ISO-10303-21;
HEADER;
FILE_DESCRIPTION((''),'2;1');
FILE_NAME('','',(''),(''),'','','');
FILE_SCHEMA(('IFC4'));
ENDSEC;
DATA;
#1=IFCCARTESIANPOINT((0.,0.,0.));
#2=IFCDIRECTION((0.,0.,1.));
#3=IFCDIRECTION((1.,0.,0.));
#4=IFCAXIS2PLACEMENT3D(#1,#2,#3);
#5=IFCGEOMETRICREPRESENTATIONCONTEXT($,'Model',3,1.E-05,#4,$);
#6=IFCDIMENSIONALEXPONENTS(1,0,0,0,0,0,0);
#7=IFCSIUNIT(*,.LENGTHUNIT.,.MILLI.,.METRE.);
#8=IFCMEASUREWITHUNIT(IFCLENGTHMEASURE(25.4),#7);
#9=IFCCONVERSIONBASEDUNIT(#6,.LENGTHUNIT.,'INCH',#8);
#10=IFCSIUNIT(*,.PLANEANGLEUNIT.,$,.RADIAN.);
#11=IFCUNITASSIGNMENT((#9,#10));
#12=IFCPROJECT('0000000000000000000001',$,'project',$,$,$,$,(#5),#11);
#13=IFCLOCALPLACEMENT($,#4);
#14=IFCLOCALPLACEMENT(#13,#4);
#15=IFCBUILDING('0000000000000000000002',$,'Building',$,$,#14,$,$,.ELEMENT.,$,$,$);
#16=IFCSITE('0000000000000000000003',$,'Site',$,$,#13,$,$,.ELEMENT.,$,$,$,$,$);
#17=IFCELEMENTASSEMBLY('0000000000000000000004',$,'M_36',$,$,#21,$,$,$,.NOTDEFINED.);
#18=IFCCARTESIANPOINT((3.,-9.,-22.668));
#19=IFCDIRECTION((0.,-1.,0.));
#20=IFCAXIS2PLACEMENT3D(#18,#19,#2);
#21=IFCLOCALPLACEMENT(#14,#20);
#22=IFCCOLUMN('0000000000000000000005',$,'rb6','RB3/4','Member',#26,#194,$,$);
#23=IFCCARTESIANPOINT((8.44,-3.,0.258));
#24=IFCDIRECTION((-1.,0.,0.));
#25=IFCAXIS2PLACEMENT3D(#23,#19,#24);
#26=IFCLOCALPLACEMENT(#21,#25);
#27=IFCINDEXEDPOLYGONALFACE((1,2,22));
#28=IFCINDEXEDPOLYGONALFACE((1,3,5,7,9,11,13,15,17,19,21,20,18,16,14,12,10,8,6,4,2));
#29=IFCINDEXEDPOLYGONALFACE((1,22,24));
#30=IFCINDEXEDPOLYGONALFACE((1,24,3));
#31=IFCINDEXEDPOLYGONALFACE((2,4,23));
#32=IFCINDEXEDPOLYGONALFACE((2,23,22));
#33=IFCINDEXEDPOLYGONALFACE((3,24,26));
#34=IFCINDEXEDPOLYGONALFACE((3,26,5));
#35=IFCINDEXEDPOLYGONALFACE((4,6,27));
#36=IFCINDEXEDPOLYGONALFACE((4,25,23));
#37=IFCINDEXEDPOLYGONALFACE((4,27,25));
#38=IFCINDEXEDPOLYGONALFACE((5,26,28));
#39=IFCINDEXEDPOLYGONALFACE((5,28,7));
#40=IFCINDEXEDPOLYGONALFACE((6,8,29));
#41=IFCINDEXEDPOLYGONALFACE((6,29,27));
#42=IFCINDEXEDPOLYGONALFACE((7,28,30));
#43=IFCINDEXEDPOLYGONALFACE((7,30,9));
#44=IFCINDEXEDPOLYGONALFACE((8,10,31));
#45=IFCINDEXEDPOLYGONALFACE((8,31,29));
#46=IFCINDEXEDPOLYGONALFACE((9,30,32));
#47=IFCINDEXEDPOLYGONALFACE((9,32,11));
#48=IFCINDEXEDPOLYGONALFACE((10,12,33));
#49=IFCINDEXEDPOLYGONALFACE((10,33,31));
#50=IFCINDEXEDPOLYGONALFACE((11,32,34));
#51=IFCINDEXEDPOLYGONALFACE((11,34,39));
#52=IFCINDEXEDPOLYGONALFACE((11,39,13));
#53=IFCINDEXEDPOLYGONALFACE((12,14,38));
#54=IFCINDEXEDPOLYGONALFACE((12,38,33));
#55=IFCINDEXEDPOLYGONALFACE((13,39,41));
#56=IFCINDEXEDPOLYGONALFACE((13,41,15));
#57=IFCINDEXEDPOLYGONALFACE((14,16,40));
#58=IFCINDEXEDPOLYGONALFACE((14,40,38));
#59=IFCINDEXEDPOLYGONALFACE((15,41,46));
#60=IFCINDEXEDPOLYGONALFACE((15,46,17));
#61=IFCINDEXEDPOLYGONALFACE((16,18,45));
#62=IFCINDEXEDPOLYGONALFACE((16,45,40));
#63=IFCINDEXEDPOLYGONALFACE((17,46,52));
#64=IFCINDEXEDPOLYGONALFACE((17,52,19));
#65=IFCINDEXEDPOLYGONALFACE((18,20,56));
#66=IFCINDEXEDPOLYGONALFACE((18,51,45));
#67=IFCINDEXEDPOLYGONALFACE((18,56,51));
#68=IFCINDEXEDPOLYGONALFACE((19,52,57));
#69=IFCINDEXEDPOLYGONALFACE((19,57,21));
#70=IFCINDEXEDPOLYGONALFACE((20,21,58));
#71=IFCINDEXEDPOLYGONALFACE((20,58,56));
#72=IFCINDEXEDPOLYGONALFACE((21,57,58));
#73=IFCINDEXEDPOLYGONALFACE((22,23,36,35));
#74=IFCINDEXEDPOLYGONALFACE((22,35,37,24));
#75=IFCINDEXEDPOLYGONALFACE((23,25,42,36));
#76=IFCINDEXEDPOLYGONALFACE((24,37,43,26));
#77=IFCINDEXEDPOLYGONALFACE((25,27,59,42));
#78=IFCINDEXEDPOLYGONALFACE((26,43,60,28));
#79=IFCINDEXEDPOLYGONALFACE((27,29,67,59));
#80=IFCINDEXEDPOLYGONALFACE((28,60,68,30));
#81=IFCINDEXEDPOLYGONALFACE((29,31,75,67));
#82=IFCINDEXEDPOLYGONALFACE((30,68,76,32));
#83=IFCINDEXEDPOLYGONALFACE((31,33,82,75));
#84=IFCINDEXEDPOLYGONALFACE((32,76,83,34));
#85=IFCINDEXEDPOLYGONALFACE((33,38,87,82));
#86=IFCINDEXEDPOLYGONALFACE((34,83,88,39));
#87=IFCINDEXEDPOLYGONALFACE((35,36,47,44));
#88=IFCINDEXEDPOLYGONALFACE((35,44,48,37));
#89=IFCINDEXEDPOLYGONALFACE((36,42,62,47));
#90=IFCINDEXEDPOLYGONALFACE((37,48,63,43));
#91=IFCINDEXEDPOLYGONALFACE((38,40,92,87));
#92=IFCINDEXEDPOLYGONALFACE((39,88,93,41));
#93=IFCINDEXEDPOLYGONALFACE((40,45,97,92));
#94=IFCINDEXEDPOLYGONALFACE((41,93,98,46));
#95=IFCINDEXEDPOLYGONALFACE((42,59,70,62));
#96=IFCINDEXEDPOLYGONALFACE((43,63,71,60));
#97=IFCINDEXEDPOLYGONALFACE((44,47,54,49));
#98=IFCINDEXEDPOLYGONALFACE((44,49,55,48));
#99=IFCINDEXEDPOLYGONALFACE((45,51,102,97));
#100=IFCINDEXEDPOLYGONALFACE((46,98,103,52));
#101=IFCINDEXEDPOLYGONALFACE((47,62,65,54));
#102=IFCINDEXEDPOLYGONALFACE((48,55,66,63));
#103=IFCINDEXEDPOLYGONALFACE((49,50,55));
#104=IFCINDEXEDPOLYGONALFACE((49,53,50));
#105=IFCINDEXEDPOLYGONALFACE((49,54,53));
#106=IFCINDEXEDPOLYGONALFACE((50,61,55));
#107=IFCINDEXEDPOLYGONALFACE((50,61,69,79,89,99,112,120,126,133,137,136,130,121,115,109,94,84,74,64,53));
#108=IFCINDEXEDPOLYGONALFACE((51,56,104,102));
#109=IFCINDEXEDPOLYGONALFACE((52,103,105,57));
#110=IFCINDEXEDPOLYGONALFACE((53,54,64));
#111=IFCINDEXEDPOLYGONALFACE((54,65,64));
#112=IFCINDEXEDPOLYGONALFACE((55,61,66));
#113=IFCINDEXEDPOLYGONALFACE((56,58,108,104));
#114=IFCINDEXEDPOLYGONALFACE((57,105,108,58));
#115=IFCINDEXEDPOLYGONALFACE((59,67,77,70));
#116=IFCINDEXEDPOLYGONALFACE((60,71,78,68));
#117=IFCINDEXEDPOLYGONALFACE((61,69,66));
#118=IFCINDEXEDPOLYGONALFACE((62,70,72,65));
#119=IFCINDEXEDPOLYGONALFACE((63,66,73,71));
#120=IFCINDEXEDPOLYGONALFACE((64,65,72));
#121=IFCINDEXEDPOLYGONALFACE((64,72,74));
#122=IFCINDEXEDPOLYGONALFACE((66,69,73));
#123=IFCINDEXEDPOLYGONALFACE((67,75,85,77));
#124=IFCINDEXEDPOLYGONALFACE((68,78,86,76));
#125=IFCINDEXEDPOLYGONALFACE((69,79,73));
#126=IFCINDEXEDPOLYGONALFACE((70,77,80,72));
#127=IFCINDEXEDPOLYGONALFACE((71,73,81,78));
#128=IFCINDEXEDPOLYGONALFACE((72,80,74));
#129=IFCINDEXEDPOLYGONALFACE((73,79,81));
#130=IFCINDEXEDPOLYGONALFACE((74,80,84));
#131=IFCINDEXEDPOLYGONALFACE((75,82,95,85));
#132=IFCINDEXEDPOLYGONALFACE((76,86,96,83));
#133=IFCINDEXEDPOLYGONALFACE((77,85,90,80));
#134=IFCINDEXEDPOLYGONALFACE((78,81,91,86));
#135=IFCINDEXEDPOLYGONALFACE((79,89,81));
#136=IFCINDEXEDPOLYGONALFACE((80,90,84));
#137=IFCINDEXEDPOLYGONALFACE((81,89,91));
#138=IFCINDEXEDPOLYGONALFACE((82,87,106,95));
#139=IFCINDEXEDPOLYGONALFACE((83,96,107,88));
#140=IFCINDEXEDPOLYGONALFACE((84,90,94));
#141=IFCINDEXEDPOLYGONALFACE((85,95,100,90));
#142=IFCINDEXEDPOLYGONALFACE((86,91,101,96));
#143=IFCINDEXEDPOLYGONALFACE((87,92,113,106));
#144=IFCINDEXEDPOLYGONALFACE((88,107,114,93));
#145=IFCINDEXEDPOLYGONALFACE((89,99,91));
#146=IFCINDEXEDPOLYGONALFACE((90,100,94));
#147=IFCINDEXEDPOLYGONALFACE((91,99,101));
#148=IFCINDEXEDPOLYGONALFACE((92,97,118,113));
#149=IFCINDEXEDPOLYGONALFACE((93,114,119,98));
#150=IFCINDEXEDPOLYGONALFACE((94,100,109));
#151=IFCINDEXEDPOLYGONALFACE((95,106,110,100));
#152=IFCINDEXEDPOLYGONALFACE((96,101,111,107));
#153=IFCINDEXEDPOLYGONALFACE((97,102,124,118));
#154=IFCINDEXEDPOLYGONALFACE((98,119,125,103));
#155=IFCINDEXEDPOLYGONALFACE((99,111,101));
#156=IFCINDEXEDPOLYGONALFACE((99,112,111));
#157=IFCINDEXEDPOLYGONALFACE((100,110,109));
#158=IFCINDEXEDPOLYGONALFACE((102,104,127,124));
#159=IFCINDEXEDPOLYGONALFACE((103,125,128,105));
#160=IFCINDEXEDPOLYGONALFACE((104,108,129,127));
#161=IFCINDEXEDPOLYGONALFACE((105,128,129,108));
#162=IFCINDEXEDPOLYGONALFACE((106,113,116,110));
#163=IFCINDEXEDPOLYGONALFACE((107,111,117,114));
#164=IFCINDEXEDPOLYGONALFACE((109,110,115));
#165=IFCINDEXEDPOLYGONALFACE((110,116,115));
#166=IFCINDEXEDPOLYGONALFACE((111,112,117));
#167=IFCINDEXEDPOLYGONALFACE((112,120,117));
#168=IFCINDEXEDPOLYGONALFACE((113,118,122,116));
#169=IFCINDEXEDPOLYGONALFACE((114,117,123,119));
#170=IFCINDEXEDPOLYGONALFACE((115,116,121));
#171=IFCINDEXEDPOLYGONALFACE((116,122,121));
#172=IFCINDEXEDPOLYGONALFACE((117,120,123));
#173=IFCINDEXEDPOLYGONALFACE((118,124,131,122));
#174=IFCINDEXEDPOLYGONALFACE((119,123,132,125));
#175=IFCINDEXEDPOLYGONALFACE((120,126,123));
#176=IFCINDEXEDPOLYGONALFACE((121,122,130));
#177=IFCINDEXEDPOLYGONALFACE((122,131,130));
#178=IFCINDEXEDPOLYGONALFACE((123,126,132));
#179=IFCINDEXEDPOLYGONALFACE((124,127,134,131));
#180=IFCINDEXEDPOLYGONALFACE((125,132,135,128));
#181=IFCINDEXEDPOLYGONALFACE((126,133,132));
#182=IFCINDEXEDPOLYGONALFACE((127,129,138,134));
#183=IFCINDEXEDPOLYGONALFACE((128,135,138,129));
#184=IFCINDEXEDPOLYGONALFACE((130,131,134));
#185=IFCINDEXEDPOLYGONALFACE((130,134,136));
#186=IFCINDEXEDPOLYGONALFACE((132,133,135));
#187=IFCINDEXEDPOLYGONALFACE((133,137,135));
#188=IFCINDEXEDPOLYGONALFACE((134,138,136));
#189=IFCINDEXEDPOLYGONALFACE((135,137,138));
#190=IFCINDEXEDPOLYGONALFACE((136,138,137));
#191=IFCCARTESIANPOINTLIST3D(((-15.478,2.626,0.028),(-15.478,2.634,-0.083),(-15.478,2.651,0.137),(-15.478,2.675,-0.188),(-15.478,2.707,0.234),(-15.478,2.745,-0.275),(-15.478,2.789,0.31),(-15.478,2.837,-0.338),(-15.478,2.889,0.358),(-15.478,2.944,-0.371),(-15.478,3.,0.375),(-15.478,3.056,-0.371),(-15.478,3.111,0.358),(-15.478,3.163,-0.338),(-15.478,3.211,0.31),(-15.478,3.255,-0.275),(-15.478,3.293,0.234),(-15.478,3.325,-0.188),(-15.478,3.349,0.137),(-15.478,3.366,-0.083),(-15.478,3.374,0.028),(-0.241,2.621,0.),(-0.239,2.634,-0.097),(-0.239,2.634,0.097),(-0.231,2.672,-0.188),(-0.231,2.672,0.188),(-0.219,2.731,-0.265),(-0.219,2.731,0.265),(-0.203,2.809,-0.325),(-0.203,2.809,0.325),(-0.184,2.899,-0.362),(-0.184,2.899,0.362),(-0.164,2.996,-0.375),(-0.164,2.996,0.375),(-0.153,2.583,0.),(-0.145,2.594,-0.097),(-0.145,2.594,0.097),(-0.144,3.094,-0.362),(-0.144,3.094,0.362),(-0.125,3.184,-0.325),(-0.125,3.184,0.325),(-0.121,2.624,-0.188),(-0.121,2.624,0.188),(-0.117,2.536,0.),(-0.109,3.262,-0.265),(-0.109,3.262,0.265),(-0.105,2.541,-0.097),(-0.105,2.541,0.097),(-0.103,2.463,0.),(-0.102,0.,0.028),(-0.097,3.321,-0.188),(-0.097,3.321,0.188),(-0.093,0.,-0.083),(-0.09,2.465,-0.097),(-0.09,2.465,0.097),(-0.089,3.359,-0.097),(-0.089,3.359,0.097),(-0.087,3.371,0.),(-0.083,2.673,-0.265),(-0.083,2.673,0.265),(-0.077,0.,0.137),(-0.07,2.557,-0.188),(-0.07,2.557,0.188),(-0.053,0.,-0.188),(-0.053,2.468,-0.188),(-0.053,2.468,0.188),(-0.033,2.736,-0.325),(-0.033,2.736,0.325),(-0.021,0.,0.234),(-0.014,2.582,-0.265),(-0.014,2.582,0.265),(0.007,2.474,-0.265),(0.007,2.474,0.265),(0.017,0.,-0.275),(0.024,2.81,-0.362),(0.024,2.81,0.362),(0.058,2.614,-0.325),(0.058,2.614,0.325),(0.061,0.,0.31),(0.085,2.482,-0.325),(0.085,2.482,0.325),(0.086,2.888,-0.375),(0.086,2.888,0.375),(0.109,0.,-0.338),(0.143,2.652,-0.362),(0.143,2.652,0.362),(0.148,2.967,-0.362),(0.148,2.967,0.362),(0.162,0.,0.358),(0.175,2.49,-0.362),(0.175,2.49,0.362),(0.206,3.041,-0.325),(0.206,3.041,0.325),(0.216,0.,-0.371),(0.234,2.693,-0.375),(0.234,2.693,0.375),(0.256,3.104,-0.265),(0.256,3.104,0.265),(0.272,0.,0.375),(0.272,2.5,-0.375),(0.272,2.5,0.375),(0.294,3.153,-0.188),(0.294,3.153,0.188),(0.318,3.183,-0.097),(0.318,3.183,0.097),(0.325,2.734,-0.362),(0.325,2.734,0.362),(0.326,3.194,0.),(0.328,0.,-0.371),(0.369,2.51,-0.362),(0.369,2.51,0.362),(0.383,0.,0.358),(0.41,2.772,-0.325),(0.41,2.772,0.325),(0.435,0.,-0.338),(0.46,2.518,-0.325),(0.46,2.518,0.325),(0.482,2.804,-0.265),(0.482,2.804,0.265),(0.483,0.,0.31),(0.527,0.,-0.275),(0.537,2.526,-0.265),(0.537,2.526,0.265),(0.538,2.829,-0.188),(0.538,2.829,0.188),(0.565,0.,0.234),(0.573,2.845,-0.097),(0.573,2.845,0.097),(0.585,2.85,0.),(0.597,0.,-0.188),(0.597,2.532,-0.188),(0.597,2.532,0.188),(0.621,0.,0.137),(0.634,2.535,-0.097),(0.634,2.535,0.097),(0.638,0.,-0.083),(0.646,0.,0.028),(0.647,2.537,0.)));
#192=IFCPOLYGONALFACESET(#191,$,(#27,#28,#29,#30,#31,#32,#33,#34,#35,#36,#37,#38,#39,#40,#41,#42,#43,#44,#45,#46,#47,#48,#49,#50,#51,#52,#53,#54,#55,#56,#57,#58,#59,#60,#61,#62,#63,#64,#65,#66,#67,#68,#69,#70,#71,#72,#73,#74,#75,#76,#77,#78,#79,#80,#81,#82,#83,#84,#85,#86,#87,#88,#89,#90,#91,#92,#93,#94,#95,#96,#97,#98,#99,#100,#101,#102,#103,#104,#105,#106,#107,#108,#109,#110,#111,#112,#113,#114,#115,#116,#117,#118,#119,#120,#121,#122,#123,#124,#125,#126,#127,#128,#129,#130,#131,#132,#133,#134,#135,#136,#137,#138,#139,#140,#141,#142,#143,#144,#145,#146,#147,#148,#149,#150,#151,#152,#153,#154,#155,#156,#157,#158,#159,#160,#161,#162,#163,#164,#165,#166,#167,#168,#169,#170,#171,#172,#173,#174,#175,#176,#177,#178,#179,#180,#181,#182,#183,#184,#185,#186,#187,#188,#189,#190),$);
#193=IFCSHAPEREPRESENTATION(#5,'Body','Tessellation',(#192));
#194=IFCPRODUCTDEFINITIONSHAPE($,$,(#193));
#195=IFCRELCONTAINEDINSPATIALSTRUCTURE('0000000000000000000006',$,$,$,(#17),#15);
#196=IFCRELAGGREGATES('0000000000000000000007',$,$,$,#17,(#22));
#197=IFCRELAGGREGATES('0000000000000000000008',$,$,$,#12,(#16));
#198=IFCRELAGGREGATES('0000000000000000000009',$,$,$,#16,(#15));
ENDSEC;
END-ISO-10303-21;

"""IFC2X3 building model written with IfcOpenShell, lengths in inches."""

from ifc_helpers import new_model, entity, si_unit, converted_unit, frame, origin_with_axes, place, context, project, spatial, element, aggregate, save


model = new_model("IFC2X3")

# Units and contexts
model_context = context("Model", 3, precision=1e-05, world=origin_with_axes())
ifc_project = project(units=[converted_unit("LENGTHUNIT", "INCH", entity("IfcLengthMeasure", 25.4), si_unit("LENGTHUNIT", "METRE", prefix="MILLI"), dimensions=[1, 0, 0, 0, 0, 0, 0]), si_unit("PLANEANGLEUNIT", "RADIAN")], contexts=[model_context])

# Site, building
site_placement = place(None, origin_with_axes())
site = spatial("IfcSite", under=ifc_project, at=site_placement, Name="Site", CompositionType="ELEMENT")
building_placement = place(site_placement, origin_with_axes())
building = spatial("IfcBuilding", under=site, at=building_placement, Name="Building", CompositionType="ELEMENT")

# Element assembly, column
assembly_placement = place(building_placement, frame((3.0, -9.0, -22.668), z_axis=(0.0, -1.0, 0.0), x_axis=(0.0, 0.0, 1.0)))
assembly = element("IfcElementAssembly", 1, at=assembly_placement, inside=building, Name="M_36", PredefinedType="NOTDEFINED")
column_placement = place(assembly_placement, frame((8.44, -3.0, 0.258), z_axis=(0.0, -1.0, 0.0), x_axis=(-1.0, 0.0, 0.0)))
cartesian_point = entity("IfcCartesianPoint", [0.0, 0.0, 0.0])
ifc_direction_1 = entity("IfcDirection", [0.0, 0.0, 1.0])
ifc_direction_2 = entity("IfcDirection", [1.0, 0.0, 0.0])
column = element("IfcColumn", 2, at=column_placement, Name="rb6", Description="RB3/4", ObjectType="Member", context=model_context, shape_type="SweptSolid", body=[
    entity("IfcSurfaceCurveSweptAreaSolid", entity("IfcCircleProfileDef", "AREA", None, entity("IfcAxis2Placement2D", entity("IfcCartesianPoint", [0.0, 0.0]), entity("IfcDirection", [1.0, 0.0])), 0.375), entity("IfcAxis2Placement3D", cartesian_point, ifc_direction_1, ifc_direction_2), entity("IfcPolyline", [entity("IfcCartesianPoint", [0.272, 0.0]), entity("IfcCartesianPoint", [0.272, 2.5]), entity("IfcCartesianPoint", [0.234, 2.693]), entity("IfcCartesianPoint", [0.086, 2.888]), entity("IfcCartesianPoint", [-0.164, 2.996]), entity("IfcCartesianPoint", [-15.478, 3.0])]), 0.0, 1.0, entity("IfcPlane", entity("IfcAxis2Placement3D", cartesian_point, ifc_direction_1, ifc_direction_2))),
])
aggregate(assembly, [column])

save(model, "model.ifc")
